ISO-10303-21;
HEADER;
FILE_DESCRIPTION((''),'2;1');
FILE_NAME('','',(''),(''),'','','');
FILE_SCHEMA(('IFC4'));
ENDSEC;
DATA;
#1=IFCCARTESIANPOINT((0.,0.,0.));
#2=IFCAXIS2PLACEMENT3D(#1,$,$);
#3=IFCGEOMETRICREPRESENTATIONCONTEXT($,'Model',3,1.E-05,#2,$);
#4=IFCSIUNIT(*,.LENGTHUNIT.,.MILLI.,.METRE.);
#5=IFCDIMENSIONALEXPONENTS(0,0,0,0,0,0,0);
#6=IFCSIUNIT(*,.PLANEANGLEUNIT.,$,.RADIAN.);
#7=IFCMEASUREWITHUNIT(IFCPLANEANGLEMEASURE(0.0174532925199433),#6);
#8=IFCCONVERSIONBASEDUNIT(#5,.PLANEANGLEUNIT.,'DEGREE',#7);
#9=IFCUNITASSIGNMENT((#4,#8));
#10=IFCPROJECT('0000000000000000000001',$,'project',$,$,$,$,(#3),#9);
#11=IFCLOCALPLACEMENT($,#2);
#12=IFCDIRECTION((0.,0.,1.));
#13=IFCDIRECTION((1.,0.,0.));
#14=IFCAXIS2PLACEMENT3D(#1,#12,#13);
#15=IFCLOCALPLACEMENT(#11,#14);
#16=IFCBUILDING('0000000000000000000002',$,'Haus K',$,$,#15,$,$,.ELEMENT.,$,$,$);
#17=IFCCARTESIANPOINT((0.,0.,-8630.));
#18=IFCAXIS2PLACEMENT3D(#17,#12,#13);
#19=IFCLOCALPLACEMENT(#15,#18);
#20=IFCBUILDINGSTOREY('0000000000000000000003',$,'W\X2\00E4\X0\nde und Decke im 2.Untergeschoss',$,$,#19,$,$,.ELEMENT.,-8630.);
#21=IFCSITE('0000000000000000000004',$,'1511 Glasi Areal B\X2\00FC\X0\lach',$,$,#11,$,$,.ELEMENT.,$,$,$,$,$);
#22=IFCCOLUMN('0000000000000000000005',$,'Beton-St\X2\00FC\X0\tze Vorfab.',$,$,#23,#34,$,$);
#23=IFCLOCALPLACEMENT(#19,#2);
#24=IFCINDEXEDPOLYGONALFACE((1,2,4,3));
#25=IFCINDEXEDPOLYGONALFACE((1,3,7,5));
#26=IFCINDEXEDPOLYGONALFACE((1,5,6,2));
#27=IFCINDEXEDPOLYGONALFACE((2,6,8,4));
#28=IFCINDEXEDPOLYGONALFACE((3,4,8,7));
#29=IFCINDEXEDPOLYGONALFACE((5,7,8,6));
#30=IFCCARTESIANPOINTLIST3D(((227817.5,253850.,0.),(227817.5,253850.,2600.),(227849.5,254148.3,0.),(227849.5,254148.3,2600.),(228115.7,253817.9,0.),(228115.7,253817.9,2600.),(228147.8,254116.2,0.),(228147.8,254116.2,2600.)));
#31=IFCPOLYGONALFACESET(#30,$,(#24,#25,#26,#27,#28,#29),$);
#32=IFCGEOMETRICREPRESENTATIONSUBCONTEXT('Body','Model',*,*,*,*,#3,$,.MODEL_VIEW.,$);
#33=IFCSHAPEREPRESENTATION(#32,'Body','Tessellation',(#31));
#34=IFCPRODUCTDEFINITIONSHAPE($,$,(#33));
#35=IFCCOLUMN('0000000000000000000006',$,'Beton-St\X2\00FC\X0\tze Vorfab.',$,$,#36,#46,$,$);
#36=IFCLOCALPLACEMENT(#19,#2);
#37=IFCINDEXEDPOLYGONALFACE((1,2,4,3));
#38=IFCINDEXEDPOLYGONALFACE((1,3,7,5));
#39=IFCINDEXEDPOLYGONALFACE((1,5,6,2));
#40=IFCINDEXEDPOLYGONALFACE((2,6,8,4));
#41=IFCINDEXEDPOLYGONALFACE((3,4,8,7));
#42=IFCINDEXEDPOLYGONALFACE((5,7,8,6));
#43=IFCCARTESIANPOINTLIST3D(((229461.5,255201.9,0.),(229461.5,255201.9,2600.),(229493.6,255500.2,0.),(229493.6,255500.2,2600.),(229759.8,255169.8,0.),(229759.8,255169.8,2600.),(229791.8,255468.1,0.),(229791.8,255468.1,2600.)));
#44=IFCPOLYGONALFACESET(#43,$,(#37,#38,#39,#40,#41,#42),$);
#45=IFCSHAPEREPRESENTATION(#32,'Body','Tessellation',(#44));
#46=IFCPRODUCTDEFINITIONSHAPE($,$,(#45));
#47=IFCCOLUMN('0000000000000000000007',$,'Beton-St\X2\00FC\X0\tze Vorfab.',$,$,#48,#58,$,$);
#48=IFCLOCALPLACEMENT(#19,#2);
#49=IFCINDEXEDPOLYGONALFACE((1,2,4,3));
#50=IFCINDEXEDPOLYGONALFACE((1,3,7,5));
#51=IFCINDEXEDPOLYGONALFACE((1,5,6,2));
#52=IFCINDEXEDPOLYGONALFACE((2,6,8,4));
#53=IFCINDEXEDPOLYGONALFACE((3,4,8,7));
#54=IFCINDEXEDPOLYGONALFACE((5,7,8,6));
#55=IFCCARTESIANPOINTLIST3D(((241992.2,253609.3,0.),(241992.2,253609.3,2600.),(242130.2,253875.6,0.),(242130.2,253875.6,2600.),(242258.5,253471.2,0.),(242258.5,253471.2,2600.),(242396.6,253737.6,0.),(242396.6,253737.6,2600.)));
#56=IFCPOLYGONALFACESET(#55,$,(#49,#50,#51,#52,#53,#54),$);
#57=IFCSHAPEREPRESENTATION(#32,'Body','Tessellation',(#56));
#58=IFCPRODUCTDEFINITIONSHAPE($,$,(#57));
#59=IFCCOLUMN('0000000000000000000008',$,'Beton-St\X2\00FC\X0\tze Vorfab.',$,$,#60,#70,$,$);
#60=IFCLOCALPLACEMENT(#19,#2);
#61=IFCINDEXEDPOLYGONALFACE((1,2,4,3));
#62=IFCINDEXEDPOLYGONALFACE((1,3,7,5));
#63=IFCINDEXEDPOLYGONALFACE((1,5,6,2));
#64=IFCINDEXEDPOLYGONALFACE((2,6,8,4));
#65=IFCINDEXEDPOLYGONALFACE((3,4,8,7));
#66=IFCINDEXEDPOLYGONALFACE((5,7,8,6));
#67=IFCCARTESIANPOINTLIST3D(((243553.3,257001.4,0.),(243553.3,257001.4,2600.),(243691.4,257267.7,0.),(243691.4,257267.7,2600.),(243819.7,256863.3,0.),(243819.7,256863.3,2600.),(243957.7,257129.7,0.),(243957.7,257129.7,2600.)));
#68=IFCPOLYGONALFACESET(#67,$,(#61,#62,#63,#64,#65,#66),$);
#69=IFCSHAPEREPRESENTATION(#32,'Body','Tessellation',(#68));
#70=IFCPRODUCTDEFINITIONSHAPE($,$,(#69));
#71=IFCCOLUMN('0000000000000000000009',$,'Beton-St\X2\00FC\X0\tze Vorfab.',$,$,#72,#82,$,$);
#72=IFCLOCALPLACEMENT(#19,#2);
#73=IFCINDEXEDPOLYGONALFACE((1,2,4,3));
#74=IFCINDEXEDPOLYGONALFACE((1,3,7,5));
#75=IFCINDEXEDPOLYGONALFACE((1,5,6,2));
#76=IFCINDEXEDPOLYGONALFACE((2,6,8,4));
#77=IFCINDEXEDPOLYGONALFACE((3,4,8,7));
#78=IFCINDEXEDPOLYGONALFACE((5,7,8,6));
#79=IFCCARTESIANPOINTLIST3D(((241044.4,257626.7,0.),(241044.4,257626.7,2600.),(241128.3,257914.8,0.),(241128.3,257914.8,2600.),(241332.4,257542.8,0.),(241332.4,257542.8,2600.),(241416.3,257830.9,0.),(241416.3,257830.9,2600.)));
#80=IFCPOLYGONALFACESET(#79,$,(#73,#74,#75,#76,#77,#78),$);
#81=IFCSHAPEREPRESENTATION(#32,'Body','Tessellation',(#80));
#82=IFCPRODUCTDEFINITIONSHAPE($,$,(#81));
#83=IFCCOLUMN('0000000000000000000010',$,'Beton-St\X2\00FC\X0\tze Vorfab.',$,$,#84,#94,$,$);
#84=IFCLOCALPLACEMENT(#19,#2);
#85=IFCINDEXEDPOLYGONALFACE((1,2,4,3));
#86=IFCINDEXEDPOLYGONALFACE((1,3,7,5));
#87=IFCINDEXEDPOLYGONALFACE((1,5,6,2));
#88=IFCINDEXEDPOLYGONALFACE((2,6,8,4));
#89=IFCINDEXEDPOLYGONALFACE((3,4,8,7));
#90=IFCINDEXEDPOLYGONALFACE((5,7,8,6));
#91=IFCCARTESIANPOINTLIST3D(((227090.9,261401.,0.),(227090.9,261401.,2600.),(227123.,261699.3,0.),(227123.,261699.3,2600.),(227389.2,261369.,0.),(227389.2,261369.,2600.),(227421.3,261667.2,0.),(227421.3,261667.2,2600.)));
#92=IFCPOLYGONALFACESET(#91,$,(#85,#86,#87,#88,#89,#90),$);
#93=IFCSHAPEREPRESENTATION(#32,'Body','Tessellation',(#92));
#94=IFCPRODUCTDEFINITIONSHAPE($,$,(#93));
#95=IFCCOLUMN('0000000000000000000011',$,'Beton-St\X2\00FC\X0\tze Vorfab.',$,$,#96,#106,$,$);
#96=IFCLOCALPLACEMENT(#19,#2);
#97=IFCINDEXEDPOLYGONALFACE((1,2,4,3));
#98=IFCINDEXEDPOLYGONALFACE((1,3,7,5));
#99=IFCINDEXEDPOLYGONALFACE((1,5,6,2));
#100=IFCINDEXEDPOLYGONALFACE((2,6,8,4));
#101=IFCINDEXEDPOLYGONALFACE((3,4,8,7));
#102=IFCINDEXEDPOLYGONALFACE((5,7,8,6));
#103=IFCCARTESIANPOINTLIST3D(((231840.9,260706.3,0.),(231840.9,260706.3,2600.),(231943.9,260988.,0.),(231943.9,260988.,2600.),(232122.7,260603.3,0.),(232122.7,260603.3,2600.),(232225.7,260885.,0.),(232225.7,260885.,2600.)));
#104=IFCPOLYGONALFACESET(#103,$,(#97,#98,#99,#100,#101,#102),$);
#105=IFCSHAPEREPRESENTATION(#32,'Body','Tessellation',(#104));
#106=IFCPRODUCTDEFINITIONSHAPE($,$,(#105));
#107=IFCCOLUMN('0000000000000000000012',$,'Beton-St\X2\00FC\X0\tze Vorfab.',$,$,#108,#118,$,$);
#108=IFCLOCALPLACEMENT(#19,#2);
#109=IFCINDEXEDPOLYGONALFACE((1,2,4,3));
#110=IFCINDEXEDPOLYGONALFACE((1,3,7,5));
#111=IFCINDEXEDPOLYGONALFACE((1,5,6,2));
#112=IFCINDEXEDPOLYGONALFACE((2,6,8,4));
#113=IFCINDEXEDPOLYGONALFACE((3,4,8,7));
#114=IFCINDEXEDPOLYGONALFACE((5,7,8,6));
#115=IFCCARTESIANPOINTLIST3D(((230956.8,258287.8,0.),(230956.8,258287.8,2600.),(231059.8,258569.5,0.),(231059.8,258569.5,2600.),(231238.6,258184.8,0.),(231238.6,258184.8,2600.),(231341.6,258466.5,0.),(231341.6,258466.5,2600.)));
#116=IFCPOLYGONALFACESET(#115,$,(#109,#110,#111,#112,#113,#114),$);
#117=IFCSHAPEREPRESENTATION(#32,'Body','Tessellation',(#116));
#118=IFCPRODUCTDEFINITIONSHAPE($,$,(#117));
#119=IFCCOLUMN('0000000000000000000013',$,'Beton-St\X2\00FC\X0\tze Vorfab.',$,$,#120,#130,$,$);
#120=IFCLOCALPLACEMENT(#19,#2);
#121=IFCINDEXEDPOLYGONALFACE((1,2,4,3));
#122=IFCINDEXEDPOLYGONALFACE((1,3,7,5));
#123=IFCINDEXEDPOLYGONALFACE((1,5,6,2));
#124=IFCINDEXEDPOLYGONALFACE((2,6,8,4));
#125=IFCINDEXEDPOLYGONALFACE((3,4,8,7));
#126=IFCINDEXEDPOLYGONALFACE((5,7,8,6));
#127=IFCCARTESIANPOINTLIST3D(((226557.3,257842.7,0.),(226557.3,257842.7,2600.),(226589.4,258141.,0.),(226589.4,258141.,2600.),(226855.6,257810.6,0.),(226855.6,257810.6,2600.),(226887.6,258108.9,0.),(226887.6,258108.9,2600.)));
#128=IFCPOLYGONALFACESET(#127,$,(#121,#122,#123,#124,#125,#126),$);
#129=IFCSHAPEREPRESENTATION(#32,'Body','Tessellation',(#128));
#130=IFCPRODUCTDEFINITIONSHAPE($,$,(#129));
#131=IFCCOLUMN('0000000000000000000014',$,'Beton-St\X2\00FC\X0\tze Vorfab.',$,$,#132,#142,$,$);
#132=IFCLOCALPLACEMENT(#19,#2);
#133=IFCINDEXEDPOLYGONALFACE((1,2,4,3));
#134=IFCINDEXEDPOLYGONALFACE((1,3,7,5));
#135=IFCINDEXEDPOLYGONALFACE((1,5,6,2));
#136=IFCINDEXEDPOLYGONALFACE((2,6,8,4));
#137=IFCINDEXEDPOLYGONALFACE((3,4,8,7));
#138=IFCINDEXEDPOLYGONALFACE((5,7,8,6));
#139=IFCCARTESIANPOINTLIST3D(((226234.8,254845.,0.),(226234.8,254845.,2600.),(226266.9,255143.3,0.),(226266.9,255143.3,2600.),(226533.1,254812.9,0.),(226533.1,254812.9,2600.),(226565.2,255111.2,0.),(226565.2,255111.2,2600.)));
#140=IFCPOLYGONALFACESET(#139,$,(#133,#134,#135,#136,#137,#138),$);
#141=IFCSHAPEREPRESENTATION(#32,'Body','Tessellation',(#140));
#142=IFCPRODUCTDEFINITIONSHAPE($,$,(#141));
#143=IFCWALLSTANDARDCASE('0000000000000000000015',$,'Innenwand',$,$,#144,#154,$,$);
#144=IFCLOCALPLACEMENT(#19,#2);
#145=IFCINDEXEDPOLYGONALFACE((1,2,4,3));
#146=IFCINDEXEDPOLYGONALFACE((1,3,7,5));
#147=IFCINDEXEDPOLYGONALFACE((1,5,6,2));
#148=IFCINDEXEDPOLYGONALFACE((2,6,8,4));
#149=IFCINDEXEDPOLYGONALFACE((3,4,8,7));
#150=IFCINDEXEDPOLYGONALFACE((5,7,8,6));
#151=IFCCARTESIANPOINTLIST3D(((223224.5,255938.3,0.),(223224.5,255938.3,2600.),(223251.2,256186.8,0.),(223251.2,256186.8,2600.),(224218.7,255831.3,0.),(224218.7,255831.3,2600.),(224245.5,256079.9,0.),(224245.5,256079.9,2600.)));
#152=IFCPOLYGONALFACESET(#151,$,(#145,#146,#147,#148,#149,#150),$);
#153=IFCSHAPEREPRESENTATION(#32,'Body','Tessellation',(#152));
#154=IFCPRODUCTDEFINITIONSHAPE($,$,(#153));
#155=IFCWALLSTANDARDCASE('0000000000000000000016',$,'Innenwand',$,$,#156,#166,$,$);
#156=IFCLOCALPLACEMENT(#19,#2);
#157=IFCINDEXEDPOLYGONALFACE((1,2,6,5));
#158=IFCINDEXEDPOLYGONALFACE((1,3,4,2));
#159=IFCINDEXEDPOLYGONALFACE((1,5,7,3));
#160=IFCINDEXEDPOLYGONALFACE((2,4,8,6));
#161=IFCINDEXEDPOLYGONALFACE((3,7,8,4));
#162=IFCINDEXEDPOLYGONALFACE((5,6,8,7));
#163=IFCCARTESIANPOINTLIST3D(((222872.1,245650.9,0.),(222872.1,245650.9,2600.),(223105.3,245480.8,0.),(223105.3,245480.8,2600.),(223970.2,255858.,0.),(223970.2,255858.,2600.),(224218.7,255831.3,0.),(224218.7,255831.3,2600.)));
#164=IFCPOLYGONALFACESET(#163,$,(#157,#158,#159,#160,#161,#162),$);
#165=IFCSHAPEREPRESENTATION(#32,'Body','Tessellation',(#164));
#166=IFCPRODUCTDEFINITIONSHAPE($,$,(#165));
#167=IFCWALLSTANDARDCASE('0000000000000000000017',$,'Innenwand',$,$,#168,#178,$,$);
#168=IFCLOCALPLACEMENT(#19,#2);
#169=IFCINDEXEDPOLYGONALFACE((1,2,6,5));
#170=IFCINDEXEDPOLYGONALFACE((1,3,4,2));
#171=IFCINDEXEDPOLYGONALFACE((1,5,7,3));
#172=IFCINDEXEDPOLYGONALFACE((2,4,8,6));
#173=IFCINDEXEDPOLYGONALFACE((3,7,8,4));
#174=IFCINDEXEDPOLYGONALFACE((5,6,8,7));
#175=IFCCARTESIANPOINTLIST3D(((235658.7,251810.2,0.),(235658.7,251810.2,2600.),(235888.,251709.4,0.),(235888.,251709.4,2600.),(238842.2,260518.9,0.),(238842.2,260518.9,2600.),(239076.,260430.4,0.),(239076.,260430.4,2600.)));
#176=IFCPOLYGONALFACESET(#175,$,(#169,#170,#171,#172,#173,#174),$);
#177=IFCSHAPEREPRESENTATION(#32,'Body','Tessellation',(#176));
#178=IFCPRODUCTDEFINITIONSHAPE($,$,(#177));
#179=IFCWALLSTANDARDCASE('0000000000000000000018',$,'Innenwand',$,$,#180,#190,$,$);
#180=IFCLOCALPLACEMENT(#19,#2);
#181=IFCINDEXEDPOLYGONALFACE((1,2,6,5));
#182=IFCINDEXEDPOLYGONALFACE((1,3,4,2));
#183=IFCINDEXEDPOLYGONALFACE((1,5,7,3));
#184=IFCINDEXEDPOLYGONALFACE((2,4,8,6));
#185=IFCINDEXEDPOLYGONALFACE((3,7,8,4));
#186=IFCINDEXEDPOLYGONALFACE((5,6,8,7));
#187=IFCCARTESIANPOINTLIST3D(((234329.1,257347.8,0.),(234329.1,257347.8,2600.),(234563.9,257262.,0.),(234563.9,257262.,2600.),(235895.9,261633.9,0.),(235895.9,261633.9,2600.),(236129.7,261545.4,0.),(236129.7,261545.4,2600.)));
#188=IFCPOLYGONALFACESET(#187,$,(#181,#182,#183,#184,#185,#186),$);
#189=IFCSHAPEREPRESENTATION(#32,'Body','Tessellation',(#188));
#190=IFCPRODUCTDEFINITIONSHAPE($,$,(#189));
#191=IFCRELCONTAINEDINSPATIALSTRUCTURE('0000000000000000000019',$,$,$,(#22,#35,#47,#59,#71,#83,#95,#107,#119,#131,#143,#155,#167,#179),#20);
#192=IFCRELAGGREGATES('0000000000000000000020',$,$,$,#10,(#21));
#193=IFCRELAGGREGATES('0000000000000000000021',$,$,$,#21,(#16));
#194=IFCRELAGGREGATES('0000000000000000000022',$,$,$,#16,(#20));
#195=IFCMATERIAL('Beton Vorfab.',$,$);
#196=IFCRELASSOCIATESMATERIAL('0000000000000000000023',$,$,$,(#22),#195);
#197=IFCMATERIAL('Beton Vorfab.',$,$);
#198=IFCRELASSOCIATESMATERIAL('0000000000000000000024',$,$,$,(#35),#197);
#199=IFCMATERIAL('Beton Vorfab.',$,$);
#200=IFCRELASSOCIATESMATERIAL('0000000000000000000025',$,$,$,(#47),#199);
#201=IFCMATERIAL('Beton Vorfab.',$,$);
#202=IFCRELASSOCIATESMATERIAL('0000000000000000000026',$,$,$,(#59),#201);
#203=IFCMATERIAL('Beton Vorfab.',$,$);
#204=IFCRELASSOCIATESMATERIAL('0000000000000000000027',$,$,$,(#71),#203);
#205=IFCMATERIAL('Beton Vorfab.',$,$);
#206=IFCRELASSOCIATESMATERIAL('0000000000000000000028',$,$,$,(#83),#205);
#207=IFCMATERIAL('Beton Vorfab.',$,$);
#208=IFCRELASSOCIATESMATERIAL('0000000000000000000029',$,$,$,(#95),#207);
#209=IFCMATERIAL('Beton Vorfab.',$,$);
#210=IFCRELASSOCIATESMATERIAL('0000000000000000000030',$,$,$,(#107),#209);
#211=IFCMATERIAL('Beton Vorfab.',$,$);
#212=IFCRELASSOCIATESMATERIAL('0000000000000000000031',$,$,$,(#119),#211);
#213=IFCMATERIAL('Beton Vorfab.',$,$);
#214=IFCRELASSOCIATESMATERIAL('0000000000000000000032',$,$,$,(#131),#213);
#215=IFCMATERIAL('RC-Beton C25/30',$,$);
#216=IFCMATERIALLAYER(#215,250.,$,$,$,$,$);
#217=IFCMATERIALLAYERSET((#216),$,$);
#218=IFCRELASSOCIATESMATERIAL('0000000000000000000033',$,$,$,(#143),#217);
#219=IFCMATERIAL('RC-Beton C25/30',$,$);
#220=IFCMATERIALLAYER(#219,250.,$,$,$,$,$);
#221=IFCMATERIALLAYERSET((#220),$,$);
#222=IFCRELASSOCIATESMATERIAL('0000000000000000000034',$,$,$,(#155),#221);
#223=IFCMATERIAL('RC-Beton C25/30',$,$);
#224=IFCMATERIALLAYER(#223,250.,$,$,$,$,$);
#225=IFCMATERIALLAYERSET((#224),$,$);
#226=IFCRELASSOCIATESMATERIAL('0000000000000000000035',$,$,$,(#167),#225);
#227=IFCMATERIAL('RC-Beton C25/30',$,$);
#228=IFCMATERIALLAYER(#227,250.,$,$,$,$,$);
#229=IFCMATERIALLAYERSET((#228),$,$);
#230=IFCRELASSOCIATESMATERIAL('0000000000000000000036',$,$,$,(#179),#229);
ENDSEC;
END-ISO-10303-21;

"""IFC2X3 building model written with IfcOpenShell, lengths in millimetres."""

from ifc_helpers import new_model, entity, si_unit, converted_unit, frame, frame_2d, origin, origin_with_axes, place, context, subcontext, project, spatial, polyline, rectangle, outline, extrude, material, layer, layer_set, layer_usage, element, save


model = new_model("IFC2X3")

# Units and contexts
model_context = context("Model", 3, precision=1e-05, world=origin())
body_context = subcontext(model_context, "Body", "Model", "MODEL_VIEW")
ifc_project = project(units=[si_unit("LENGTHUNIT", "METRE", prefix="MILLI"), converted_unit("PLANEANGLEUNIT", "DEGREE", entity("IfcPlaneAngleMeasure", 0.0174532925199433), si_unit("PLANEANGLEUNIT", "RADIAN"), dimensions=[0, 0, 0, 0, 0, 0, 0])], contexts=[model_context])

# Site, building, storey
site_placement = place(None, origin())
site = spatial("IfcSite", under=ifc_project, at=site_placement, Name="1511 Glasi Areal Bülach", CompositionType="ELEMENT")
building_placement = place(site_placement, origin_with_axes())
building = spatial("IfcBuilding", under=site, at=building_placement, Name="Haus K", CompositionType="ELEMENT")
storey_placement = place(building_placement, frame((0.0, 0.0, -8630.0), z_axis=(0.0, 0.0, 1.0), x_axis=(1.0, 0.0, 0.0)))
storey = spatial("IfcBuildingStorey", under=building, at=storey_placement, Name="Wände und Decke im 2.Untergeschoss", CompositionType="ELEMENT", Elevation=-8630.0)

# Columns
ifc_material_1 = material(Name="Beton Vorfab.")
column_1_placement = place(storey_placement, frame((227817.5, 253850.0, 0.0), z_axis=(0.0, 0.0, 1.0), x_axis=(1.0, 0.0, 0.0)))
element("IfcColumn", 1, at=column_1_placement, inside=storey, material=ifc_material_1, Name="Beton-Stütze Vorfab.", context=body_context, shape_type="SweptSolid", body=[
    extrude(rectangle(XDim=300.0, YDim=300.0, at=frame_2d((165.2, 133.1), x_axis=(0.994264, -0.106958))), origin_with_axes(), (0.0, 0.0, 1.0), 2600.0),
])
ifc_material_2 = material(Name="Beton Vorfab.")
column_2_placement = place(storey_placement, frame((229461.5, 255201.9, 0.0), z_axis=(0.0, 0.0, 1.0), x_axis=(1.0, 0.0, 0.0)))
element("IfcColumn", 2, at=column_2_placement, inside=storey, material=ifc_material_2, Name="Beton-Stütze Vorfab.", context=body_context, shape_type="SweptSolid", body=[
    extrude(rectangle(XDim=300.0, YDim=300.0, at=frame_2d((165.2, 133.1), x_axis=(0.994264, -0.106958))), origin_with_axes(), (0.0, 0.0, 1.0), 2600.0),
])
ifc_material_3 = material(Name="Beton Vorfab.")
column_3_placement = place(storey_placement, frame((241992.2, 253609.3, 0.0), z_axis=(0.0, 0.0, 1.0), x_axis=(1.0, 0.0, 0.0)))
element("IfcColumn", 3, at=column_3_placement, inside=storey, material=ifc_material_3, Name="Beton-Stütze Vorfab.", context=body_context, shape_type="SweptSolid", body=[
    extrude(rectangle(XDim=300.0, YDim=300.0, at=frame_2d((202.2, 64.1), x_axis=(0.887815, -0.4602))), origin_with_axes(), (0.0, 0.0, 1.0), 2600.0),
])
ifc_material_4 = material(Name="Beton Vorfab.")
column_4_placement = place(storey_placement, frame((243553.3, 257001.4, 0.0), z_axis=(0.0, 0.0, 1.0), x_axis=(1.0, 0.0, 0.0)))
element("IfcColumn", 4, at=column_4_placement, inside=storey, material=ifc_material_4, Name="Beton-Stütze Vorfab.", context=body_context, shape_type="SweptSolid", body=[
    extrude(rectangle(XDim=300.0, YDim=300.0, at=frame_2d((202.2, 64.1), x_axis=(0.887815, -0.4602))), origin_with_axes(), (0.0, 0.0, 1.0), 2600.0),
])
ifc_material_5 = material(Name="Beton Vorfab.")
column_5_placement = place(storey_placement, frame((241044.4, 257626.7, 0.0), z_axis=(0.0, 0.0, 1.0), x_axis=(1.0, 0.0, 0.0)))
element("IfcColumn", 5, at=column_5_placement, inside=storey, material=ifc_material_5, Name="Beton-Stütze Vorfab.", context=body_context, shape_type="SweptSolid", body=[
    extrude(rectangle(XDim=300.0, YDim=300.0, at=frame_2d((186.0, 102.1), x_axis=(0.960099, -0.279661))), origin_with_axes(), (0.0, 0.0, 1.0), 2600.0),
])
ifc_material_6 = material(Name="Beton Vorfab.")
column_6_placement = place(storey_placement, frame((227090.9, 261401.0, 0.0), z_axis=(0.0, 0.0, 1.0), x_axis=(1.0, 0.0, 0.0)))
element("IfcColumn", 6, at=column_6_placement, inside=storey, material=ifc_material_6, Name="Beton-Stütze Vorfab.", context=body_context, shape_type="SweptSolid", body=[
    extrude(rectangle(XDim=300.0, YDim=300.0, at=frame_2d((165.2, 133.1), x_axis=(0.994264, -0.106958))), origin_with_axes(), (0.0, 0.0, 1.0), 2600.0),
])
ifc_material_7 = material(Name="Beton Vorfab.")
column_7_placement = place(storey_placement, frame((231840.9, 260706.3, 0.0), z_axis=(0.0, 0.0, 1.0), x_axis=(1.0, 0.0, 0.0)))
element("IfcColumn", 7, at=column_7_placement, inside=storey, material=ifc_material_7, Name="Beton-Stütze Vorfab.", context=body_context, shape_type="SweptSolid", body=[
    extrude(rectangle(XDim=300.0, YDim=300.0, at=frame_2d((192.4, 89.4), x_axis=(0.939214, -0.343332))), origin_with_axes(), (0.0, 0.0, 1.0), 2600.0),
])
ifc_material_8 = material(Name="Beton Vorfab.")
column_8_placement = place(storey_placement, frame((230956.8, 258287.8, 0.0), z_axis=(0.0, 0.0, 1.0), x_axis=(1.0, 0.0, 0.0)))
element("IfcColumn", 8, at=column_8_placement, inside=storey, material=ifc_material_8, Name="Beton-Stütze Vorfab.", context=body_context, shape_type="SweptSolid", body=[
    extrude(rectangle(XDim=300.0, YDim=300.0, at=frame_2d((192.4, 89.4), x_axis=(0.939214, -0.343332))), origin_with_axes(), (0.0, 0.0, 1.0), 2600.0),
])
ifc_material_9 = material(Name="Beton Vorfab.")
column_9_placement = place(storey_placement, frame((226557.3, 257842.7, 0.0), z_axis=(0.0, 0.0, 1.0), x_axis=(1.0, 0.0, 0.0)))
element("IfcColumn", 9, at=column_9_placement, inside=storey, material=ifc_material_9, Name="Beton-Stütze Vorfab.", context=body_context, shape_type="SweptSolid", body=[
    extrude(rectangle(XDim=300.0, YDim=300.0, at=frame_2d((165.2, 133.1), x_axis=(0.994264, -0.106958))), origin_with_axes(), (0.0, 0.0, 1.0), 2600.0),
])
ifc_material_10 = material(Name="Beton Vorfab.")
column_10_placement = place(storey_placement, frame((226234.8, 254845.0, 0.0), z_axis=(0.0, 0.0, 1.0), x_axis=(1.0, 0.0, 0.0)))
element("IfcColumn", 10, at=column_10_placement, inside=storey, material=ifc_material_10, Name="Beton-Stütze Vorfab.", context=body_context, shape_type="SweptSolid", body=[
    extrude(rectangle(XDim=300.0, YDim=300.0, at=frame_2d((165.2, 133.1), x_axis=(0.994264, -0.106958))), origin_with_axes(), (0.0, 0.0, 1.0), 2600.0),
])

# Walls
ifc_material_11 = material(Name="RC-Beton C25/30")
ifc_layer_1 = layer(ifc_material_11, 250.0)
ifc_layer_set_1 = layer_set([ifc_layer_1])
ifc_layer_usage_1 = layer_usage(ifc_layer_set_1, "AXIS2", "POSITIVE", 0.0)
wall_1_placement = place(storey_placement, frame((223224.5, 255938.3, 0.0), z_axis=(0.0, 0.0, 1.0), x_axis=(0.994264, -0.106958, 0.0)))
element("IfcWallStandardCase", 11, at=wall_1_placement, inside=storey, material=ifc_layer_usage_1, Name="Innenwand", context=body_context, shape_type="SweptSolid", body=[
    extrude(rectangle(XDim=1000.0, YDim=250.0, at=frame_2d((500.0, 125.0), x_axis=(1.0, 0.0))), origin_with_axes(), (0.0, 0.0, 1.0), 2600.0),
])
ifc_material_12 = material(Name="RC-Beton C25/30")
ifc_layer_2 = layer(ifc_material_12, 250.0)
ifc_layer_set_2 = layer_set([ifc_layer_2])
ifc_layer_usage_2 = layer_usage(ifc_layer_set_2, "AXIS2", "POSITIVE", 0.0)
wall_2_placement = place(storey_placement, frame((223970.2, 255858.0, 0.0), z_axis=(0.0, 0.0, 1.0), x_axis=(-0.106958, -0.994264, 0.0)))
element("IfcWallStandardCase", 12, at=wall_2_placement, inside=storey, material=ifc_layer_usage_2, Name="Innenwand", context=body_context, shape_type="SweptSolid", body=[
    extrude(outline(polyline([(0.0, 0.0), (10266.0, 0.0), (10410.3, 250.0), (0.0, 250.0), (0.0, 0.0)])), origin_with_axes(), (0.0, 0.0, 1.0), 2600.0),
])
ifc_material_13 = material(Name="RC-Beton C25/30")
ifc_layer_3 = layer(ifc_material_13, 250.0)
ifc_layer_set_3 = layer_set([ifc_layer_3])
ifc_layer_usage_3 = layer_usage(ifc_layer_set_3, "AXIS2", "POSITIVE", 0.0)
wall_3_placement = place(storey_placement, frame((238842.2, 260518.9, 0.0), z_axis=(0.0, 0.0, 1.0), x_axis=(-0.343332, -0.939214, 0.0)))
element("IfcWallStandardCase", 13, at=wall_3_placement, inside=storey, material=ifc_layer_usage_3, Name="Innenwand", context=body_context, shape_type="SweptSolid", body=[
    extrude(outline(polyline([(0.0, 0.0), (9272.3, 0.0), (9288.2, 250.0), (2.8, 250.0), (0.0, 0.0)])), origin_with_axes(), (0.0, 0.0, 1.0), 2600.0),
])
ifc_material_14 = material(Name="RC-Beton C25/30")
ifc_layer_4 = layer(ifc_material_14, 250.0)
ifc_layer_set_4 = layer_set([ifc_layer_4])
ifc_layer_usage_4 = layer_usage(ifc_layer_set_4, "AXIS2", "POSITIVE", 0.0)
wall_4_placement = place(storey_placement, frame((235895.9, 261633.9, 0.0), z_axis=(0.0, 0.0, 1.0), x_axis=(-0.343332, -0.939214, 0.0)))
element("IfcWallStandardCase", 14, at=wall_4_placement, inside=storey, material=ifc_layer_usage_4, Name="Innenwand", context=body_context, shape_type="SweptSolid", body=[
    extrude(outline(polyline([(0.0, 0.0), (4563.5, 0.0), (4563.5, 250.0), (2.8, 250.0), (0.0, 0.0)])), origin_with_axes(), (0.0, 0.0, 1.0), 2600.0),
])

save(model, "model.ifc")
